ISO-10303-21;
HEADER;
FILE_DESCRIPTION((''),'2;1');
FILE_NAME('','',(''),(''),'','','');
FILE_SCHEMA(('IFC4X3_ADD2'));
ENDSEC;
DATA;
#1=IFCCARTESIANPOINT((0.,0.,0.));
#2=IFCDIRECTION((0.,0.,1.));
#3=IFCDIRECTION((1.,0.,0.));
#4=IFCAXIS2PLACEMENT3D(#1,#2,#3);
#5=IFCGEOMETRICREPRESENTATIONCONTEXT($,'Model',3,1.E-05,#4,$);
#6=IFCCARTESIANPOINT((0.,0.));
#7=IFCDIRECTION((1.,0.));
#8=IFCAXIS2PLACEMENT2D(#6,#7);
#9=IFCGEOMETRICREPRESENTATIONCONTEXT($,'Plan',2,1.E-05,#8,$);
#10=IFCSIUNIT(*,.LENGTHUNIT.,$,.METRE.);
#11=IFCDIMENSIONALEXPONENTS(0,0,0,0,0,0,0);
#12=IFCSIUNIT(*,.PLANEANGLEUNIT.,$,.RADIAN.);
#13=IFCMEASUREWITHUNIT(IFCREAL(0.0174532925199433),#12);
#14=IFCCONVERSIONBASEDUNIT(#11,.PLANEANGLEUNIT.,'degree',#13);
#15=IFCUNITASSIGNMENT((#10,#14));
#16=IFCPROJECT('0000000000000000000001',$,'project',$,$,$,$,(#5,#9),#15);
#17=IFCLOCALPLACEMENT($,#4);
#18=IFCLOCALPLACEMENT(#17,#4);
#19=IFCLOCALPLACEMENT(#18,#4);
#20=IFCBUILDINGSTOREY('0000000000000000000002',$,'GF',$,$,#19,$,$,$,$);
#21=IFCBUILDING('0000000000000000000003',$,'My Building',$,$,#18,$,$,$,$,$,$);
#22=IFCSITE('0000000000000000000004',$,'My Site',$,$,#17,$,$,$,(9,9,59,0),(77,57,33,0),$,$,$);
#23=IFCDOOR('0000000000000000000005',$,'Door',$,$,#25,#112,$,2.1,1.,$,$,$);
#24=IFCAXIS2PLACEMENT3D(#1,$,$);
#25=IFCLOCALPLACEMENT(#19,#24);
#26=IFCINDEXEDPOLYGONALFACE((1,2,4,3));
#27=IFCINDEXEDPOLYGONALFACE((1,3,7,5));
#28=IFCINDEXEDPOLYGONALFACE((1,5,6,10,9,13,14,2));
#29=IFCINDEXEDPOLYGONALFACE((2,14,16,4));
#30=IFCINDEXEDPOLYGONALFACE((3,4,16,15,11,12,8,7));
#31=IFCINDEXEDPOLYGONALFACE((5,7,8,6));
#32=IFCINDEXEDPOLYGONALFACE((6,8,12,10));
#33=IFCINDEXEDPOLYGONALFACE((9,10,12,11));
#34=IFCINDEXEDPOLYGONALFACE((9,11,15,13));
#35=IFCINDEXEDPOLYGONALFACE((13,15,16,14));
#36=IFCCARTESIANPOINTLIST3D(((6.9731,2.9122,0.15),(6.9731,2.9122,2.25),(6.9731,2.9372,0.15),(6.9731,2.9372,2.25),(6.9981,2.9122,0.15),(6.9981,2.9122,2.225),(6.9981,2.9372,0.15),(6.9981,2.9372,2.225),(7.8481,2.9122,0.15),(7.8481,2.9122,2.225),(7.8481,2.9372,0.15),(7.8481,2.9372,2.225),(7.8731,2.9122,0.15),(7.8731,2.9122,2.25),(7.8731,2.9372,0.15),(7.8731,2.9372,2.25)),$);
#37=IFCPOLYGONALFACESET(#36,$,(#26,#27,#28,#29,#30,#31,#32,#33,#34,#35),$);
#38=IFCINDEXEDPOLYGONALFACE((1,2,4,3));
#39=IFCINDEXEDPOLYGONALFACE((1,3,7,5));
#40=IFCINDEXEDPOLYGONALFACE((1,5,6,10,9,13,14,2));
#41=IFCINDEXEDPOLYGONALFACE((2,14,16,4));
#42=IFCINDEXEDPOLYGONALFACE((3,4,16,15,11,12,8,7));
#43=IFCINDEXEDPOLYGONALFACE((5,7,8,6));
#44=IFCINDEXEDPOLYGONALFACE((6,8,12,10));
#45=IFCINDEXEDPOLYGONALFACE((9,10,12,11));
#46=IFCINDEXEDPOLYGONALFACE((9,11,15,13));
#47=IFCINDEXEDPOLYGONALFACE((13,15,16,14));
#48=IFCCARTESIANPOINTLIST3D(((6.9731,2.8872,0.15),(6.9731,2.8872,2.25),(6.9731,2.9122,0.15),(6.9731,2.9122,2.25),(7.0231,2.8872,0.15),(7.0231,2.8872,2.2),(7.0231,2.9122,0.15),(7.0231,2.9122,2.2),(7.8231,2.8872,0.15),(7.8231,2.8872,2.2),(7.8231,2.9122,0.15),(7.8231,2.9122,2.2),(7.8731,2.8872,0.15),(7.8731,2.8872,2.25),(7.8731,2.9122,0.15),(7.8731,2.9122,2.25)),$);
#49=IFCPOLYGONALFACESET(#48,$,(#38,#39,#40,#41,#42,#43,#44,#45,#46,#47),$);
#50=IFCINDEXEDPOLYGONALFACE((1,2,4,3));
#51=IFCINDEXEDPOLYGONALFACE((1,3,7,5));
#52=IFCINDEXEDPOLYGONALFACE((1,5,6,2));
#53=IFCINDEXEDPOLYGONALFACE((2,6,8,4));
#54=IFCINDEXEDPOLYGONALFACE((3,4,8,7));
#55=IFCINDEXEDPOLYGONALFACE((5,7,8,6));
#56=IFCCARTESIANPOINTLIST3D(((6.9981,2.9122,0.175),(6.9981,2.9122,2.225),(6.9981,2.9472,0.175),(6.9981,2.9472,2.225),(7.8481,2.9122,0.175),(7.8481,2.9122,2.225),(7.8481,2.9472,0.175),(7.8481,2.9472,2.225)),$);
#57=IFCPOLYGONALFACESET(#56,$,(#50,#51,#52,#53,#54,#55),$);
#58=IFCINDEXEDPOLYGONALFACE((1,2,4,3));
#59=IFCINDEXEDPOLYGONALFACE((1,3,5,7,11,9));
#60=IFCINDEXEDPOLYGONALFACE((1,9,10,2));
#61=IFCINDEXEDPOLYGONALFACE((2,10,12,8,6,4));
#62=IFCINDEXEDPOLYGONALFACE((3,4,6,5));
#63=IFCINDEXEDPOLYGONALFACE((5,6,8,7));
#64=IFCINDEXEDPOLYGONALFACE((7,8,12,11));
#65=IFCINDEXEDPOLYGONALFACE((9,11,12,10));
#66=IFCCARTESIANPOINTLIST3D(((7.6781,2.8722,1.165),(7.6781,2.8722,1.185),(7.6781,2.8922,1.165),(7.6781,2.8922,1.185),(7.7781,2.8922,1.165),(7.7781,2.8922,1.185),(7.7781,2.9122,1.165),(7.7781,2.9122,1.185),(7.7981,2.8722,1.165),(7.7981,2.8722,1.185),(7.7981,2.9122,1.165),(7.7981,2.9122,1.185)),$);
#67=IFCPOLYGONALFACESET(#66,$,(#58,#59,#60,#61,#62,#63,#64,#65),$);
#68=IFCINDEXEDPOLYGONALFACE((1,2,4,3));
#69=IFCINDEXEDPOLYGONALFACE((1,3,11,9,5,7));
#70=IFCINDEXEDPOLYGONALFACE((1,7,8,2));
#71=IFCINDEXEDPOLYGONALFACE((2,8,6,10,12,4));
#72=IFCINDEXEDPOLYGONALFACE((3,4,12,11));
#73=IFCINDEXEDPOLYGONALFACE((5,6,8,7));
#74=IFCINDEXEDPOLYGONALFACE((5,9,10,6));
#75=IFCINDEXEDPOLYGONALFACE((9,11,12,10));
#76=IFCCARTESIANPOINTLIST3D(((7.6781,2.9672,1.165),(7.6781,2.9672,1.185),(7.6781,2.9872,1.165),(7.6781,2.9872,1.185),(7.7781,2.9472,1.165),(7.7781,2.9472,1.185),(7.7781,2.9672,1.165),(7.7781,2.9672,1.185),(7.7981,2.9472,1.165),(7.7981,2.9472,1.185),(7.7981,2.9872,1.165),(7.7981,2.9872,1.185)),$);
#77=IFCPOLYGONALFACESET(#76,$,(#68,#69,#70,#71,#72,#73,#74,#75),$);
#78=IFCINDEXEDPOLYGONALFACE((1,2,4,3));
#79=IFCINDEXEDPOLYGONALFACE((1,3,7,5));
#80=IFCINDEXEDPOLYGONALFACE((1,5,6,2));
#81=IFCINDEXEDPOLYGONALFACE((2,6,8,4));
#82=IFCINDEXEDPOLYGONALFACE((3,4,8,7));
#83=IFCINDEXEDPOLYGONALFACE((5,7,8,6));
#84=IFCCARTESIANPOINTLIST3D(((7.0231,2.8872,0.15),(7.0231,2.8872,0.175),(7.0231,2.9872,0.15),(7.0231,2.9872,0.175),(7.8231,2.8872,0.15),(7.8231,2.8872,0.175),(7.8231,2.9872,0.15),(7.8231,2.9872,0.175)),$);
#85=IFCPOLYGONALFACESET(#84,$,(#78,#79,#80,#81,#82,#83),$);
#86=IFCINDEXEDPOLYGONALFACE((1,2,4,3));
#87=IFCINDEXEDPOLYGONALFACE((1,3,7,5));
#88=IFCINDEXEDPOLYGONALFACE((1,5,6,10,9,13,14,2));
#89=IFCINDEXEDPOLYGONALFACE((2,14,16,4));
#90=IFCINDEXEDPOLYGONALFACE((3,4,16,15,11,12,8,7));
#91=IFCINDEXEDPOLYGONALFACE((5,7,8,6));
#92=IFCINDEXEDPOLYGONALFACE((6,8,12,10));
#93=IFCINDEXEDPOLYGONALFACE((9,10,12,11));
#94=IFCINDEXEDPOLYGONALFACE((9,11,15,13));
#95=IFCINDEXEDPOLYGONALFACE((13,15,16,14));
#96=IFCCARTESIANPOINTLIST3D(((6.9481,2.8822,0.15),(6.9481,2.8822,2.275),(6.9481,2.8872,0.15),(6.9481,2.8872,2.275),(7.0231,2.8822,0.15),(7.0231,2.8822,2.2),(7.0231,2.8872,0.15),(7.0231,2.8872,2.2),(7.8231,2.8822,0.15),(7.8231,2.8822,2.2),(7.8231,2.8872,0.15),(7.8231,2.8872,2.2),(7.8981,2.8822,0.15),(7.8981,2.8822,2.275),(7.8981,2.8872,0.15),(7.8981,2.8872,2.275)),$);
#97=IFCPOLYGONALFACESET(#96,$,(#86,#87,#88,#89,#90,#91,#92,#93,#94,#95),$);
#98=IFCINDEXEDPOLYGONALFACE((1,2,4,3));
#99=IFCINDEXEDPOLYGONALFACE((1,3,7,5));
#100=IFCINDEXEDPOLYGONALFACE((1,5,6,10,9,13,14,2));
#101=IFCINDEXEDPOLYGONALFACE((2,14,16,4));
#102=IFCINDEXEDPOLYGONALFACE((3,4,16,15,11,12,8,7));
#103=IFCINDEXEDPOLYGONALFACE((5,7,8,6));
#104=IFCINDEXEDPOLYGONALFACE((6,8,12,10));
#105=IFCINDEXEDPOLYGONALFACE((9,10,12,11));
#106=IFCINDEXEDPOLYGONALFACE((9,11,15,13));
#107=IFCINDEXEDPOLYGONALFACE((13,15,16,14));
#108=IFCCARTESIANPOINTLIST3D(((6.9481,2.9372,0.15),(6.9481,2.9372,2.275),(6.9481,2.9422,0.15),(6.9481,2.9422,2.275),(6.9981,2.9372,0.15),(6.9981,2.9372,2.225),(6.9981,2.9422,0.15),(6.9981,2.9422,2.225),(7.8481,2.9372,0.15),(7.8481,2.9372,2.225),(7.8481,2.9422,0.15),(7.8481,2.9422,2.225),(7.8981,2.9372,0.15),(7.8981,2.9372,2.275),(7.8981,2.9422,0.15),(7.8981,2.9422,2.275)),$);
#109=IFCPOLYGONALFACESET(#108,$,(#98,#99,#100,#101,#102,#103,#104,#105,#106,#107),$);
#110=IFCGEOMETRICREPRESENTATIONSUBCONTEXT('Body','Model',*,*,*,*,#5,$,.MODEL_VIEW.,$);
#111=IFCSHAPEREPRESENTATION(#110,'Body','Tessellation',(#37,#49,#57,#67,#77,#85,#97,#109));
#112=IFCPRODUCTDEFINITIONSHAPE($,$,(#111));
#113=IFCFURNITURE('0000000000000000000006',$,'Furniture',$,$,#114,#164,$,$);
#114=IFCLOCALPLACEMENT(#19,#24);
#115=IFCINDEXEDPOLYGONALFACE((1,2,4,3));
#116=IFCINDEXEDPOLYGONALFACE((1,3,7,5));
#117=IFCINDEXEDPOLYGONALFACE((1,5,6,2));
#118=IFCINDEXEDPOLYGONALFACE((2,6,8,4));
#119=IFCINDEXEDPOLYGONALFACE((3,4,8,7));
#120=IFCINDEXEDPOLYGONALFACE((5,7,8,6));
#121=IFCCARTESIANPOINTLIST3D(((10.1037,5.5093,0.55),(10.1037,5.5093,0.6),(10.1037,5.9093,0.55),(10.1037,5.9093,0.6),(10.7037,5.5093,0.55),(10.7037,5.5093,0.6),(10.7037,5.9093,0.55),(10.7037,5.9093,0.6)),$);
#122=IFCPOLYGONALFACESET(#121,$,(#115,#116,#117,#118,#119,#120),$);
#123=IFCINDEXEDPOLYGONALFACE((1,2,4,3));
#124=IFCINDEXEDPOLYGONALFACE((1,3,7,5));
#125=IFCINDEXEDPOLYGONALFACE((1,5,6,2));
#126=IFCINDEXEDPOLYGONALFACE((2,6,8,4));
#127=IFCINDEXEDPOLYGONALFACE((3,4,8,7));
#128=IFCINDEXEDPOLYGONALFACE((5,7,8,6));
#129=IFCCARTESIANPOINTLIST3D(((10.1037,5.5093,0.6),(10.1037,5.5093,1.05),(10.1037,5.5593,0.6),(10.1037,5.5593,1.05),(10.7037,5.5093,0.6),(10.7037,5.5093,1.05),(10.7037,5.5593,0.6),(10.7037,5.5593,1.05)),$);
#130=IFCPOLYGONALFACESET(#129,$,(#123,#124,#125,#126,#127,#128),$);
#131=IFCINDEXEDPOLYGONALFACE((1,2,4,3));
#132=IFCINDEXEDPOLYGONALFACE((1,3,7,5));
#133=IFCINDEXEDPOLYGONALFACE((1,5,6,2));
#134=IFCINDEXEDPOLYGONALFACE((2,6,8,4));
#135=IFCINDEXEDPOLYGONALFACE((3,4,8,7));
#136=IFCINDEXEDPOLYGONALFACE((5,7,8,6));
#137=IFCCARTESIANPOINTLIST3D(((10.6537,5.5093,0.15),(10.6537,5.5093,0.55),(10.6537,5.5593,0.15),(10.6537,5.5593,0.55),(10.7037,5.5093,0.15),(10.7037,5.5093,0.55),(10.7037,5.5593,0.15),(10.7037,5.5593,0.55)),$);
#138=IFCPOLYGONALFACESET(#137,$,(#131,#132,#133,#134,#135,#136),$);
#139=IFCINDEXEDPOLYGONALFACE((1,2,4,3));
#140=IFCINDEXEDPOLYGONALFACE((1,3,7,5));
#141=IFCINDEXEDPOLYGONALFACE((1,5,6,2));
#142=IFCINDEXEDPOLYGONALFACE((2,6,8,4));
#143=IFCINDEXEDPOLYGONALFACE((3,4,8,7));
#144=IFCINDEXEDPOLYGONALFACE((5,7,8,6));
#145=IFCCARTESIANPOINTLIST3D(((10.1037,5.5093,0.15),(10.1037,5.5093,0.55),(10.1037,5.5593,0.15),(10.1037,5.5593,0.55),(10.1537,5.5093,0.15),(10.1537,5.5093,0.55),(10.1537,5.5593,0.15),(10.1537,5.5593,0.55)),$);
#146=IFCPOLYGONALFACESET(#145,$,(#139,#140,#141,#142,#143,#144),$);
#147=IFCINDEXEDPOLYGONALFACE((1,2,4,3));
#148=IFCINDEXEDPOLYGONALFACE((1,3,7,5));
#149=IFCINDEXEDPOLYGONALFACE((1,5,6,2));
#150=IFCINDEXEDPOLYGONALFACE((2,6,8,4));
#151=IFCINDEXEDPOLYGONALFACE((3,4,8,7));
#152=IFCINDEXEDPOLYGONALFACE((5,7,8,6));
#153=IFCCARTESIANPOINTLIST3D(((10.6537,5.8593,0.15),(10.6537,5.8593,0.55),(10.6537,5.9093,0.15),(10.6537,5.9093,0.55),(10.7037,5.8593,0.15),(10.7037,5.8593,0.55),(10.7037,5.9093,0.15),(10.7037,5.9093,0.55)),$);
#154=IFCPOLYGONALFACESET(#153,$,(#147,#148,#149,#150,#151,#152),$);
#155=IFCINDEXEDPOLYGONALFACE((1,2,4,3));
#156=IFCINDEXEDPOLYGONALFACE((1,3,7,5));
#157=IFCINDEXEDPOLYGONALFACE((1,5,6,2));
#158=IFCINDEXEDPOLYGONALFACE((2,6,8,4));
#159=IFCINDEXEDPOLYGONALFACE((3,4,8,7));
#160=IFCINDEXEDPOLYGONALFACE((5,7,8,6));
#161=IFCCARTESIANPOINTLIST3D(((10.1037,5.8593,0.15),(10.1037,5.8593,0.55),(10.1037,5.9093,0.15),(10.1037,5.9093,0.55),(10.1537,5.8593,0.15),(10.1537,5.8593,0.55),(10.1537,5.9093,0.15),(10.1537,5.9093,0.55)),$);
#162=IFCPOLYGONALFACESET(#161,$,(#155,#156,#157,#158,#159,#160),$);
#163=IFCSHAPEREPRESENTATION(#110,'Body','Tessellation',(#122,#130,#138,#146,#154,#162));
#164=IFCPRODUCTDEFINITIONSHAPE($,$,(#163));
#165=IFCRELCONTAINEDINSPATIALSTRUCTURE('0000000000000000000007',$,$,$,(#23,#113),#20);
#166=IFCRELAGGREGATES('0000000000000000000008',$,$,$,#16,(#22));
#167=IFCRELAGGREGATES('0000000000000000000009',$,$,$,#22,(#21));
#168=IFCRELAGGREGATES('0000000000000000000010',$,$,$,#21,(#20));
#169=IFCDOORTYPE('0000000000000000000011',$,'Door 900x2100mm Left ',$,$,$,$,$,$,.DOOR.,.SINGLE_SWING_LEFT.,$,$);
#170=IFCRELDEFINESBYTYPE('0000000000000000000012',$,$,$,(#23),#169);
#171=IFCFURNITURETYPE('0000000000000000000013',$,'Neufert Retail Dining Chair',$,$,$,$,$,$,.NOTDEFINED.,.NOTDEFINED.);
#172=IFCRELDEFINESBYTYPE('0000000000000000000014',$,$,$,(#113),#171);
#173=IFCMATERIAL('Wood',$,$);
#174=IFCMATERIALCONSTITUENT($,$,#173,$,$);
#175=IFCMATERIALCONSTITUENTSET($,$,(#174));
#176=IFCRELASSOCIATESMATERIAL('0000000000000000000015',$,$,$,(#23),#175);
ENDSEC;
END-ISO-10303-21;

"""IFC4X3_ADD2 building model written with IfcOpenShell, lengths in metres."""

from ifc_helpers import new_model, entity, si_unit, converted_unit, frame, origin_with_axes, origin_2d_with_axis, place, context, subcontext, project, spatial, line, indexed_curve, outline, extrude, shape, source, transform, mapped, material, constituent, constituent_set, type_object, type_shapes, element, save


model = new_model("IFC4X3_ADD2")

# Units and contexts
model_context = context("Model", 3, precision=1e-05, world=origin_with_axes())
plan_context = context("Plan", 2, precision=1e-05, world=origin_2d_with_axis())
body_context_1 = subcontext(model_context, "Body", "Model", "MODEL_VIEW")
body_context_2 = subcontext(plan_context, "Body", "Plan", "PLAN_VIEW")
ifc_project = project(units=[si_unit("LENGTHUNIT", "METRE"), converted_unit("PLANEANGLEUNIT", "degree", entity("IfcReal", 0.0174532925199433), si_unit("PLANEANGLEUNIT", "RADIAN"), dimensions=[0, 0, 0, 0, 0, 0, 0])], contexts=[model_context, plan_context])

# Site, building, storey
site_placement = place(None, origin_with_axes())
site = spatial("IfcSite", under=ifc_project, at=site_placement, Name="My Site", RefLatitude=(9, 9, 59, 0), RefLongitude=(77, 57, 33, 0))
building_placement = place(site_placement, origin_with_axes())
building = spatial("IfcBuilding", under=site, at=building_placement, Name="My Building")
storey_placement = place(building_placement, origin_with_axes())
storey = spatial("IfcBuildingStorey", under=building, at=storey_placement, Name="GF")

# Door
ifc_material_1 = material(Name="Wood")
ifc_constituent = constituent(ifc_material_1)
ifc_constituent_set = constituent_set(constituents=[ifc_constituent])
door_type = type_object("IfcDoorType", Name="Door 900x2100mm Left ", OperationType="SINGLE_SWING_LEFT", PredefinedType="DOOR")
shared_shape_1 = source(origin_with_axes(), body_context_1, "Body", "SweptSolid", [
    extrude(outline(indexed_curve([(0.0, 0.0), (0.0, 2.1), (0.9, 2.1), (0.9, 0.0), (0.875, 0.0), (0.875, 2.075), (0.025, 2.075), (0.025, 0.0)], segments=[line(1, 2, 3, 4, 5, 6, 7, 8, 1)])), frame((0.0, 0.025, 0.0), z_axis=(0.0, -1.0, 0.0), x_axis=(1.0, 0.0, 0.0)), (0.0, 0.0, -1.0), 0.025),
    extrude(outline(indexed_curve([(0.0, 0.0), (0.0, 2.1), (0.9, 2.1), (0.9, 0.0), (0.85, 0.0), (0.85, 2.05), (0.05, 2.05), (0.05, 0.0)], segments=[line(1, 2, 3, 4, 5, 6, 7, 8, 1)])), frame((0.0, 0.0, 0.0), z_axis=(0.0, -1.0, 0.0), x_axis=(1.0, 0.0, 0.0)), (0.0, 0.0, -1.0), 0.025),
    extrude(outline(indexed_curve([(0.0, 0.0), (0.85, 0.0), (0.85, 0.035), (0.0, 0.035)], segments=[line(1, 2, 3, 4, 1)])), frame((0.025, 0.025, 0.025), z_axis=(0.0, 0.0, 1.0), x_axis=(1.0, 0.0, 0.0)), (0.0, 0.0, 1.0), 2.05),
    extrude(outline(indexed_curve([(0.0, 0.0), (0.0, -0.04), (-0.12, -0.04), (-0.12, -0.02), (-0.02, -0.02), (-0.02, 0.0)], segments=[line(1, 2, 3, 4, 5, 6, 1)])), frame((0.825, 0.025, 1.015), z_axis=(0.0, 0.0, 1.0), x_axis=(1.0, 0.0, 0.0)), (0.0, 0.0, 1.0), 0.02),
    extrude(outline(indexed_curve([(0.0, 0.0), (0.0, 0.04), (-0.12, 0.04), (-0.12, 0.02), (-0.02, 0.02), (-0.02, 0.0)], segments=[line(1, 2, 3, 4, 5, 6, 1)])), frame((0.825, 0.06, 1.015), z_axis=(0.0, 0.0, 1.0), x_axis=(1.0, 0.0, 0.0)), (0.0, 0.0, 1.0), 0.02),
    extrude(outline(indexed_curve([(0.0, 0.0), (0.8, 0.0), (0.8, 0.1), (0.0, 0.1)], segments=[line(1, 2, 3, 4, 1)])), frame((0.05, 0.0, 0.0), z_axis=(0.0, 0.0, 1.0), x_axis=(1.0, 0.0, 0.0)), (0.0, 0.0, 1.0), 0.025),
    extrude(outline(indexed_curve([(0.0, 0.0), (0.0, 2.125), (0.95, 2.125), (0.95, 0.0), (0.875, 0.0), (0.875, 2.05), (0.075, 2.05), (0.075, 0.0)], segments=[line(1, 2, 3, 4, 5, 6, 7, 8, 1)])), frame((-0.025, -0.005, 0.0), z_axis=(0.0, -1.0, 0.0), x_axis=(1.0, 0.0, 0.0)), (0.0, 0.0, -1.0), 0.005),
    extrude(outline(indexed_curve([(0.0, 0.0), (0.0, 2.125), (0.95, 2.125), (0.95, 0.0), (0.9, 0.0), (0.9, 2.075), (0.05, 2.075), (0.05, 0.0)], segments=[line(1, 2, 3, 4, 5, 6, 7, 8, 1)])), frame((-0.025, 0.05, 0.0), z_axis=(0.0, -1.0, 0.0), x_axis=(1.0, 0.0, 0.0)), (0.0, 0.0, -1.0), 0.005),
])
shared_shape_2 = source(origin_with_axes(), body_context_2, "Body", "Curve2D", [
    entity("IfcIndexedPolyCurve", entity("IfcCartesianPointList2D", [[0.0, 0.0], [0.0, 0.05], [0.025, 0.05], [0.025, 0.025], [0.05, 0.025], [0.05, 0.0]]), [entity("IfcLineIndex", [1, 2, 3, 4, 5, 6, 1])]),
    entity("IfcIndexedPolyCurve", entity("IfcCartesianPointList2D", [[0.9, 0.0], [0.9, 0.05], [0.875, 0.05], [0.875, 0.025], [0.85, 0.025], [0.85, 0.0]]), [entity("IfcLineIndex", [1, 2, 3, 4, 5, 6, 1])]),
    entity("IfcTrimmedCurve", entity("IfcEllipse", entity("IfcAxis2Placement2D", entity("IfcCartesianPoint", [0.06, 0.05]), entity("IfcDirection", [1.0, 0.0])), 0.815, 0.85), [entity("IfcCartesianPoint", [0.875, 0.05])], [entity("IfcCartesianPoint", [0.06, 0.9])], True, "CARTESIAN"),
    entity("IfcIndexedPolyCurve", entity("IfcCartesianPointList2D", [[0.025, 0.05], [0.06, 0.05], [0.06, 0.9], [0.025, 0.9]]), [entity("IfcLineIndex", [1, 2, 3, 4, 1])]),
])
type_shapes(door_type, [shared_shape_1, shared_shape_2])
door_placement = place(storey_placement, frame((6.9731, 2.8872, 0.15), z_axis=(0.0, 0.0, 1.0), x_axis=(1.0, 0.0, 0.0)))
element("IfcDoor", 1, at=door_placement, inside=storey, type_object=door_type, material=ifc_constituent_set, Name="Door", OverallHeight=2.1, OverallWidth=1.0, shapes=[
    shape(body_context_1, "Body", "MappedRepresentation", [mapped(shared_shape_1, transform((0.0, 0.0, 0.0), x_axis=(1.0, 0.0, 0.0), y_axis=(0.0, 1.0, 0.0), z_axis=(0.0, 0.0, 1.0), scale=1.0))]),
    shape(body_context_2, "Body", "MappedRepresentation", [mapped(shared_shape_2, transform((0.0, 0.0, 0.0), x_axis=(1.0, 0.0, 0.0), y_axis=(0.0, 1.0, 0.0), z_axis=(0.0, 0.0, 1.0), scale=1.0))]),
])

# Furniture
furniture_type = type_object("IfcFurnitureType", Name="Neufert Retail Dining Chair", AssemblyPlace="NOTDEFINED", PredefinedType="NOTDEFINED")
shared_shape_3 = source(origin_with_axes(), body_context_1, "Body", "SweptSolid", [
    extrude(outline(indexed_curve([(-0.3, 0.0), (0.3, 0.0), (0.3, -0.4), (-0.3, -0.4)], segments=[line(1, 2, 3, 4, 1)])), frame((0.0, 0.0, 0.45), z_axis=(0.0, 0.0, 1.0), x_axis=(1.0, 0.0, 0.0)), (0.0, 0.0, -1.0), 0.05),
    extrude(outline(indexed_curve([(-0.3, 0.0), (0.3, 0.0), (0.3, -0.05), (-0.3, -0.05)], segments=[line(1, 2, 3, 4, 1)])), frame((0.0, 0.0, 0.9), z_axis=(0.0, 0.0, 1.0), x_axis=(1.0, 0.0, 0.0)), (0.0, 0.0, -1.0), 0.45),
    extrude(outline(indexed_curve([(-0.3, 0.0), (-0.25, 0.0), (-0.25, -0.05), (-0.3, -0.05)], segments=[line(1, 2, 3, 4, 1)])), origin_with_axes(), (0.0, 0.0, 1.0), 0.4),
    extrude(outline(indexed_curve([(0.3, 0.0), (0.25, 0.0), (0.25, -0.05), (0.3, -0.05)], segments=[line(1, 2, 3, 4, 1)])), origin_with_axes(), (0.0, 0.0, 1.0), 0.4),
    extrude(outline(indexed_curve([(-0.3, -0.4), (-0.25, -0.4), (-0.25, -0.35), (-0.3, -0.35)], segments=[line(1, 2, 3, 4, 1)])), origin_with_axes(), (0.0, 0.0, 1.0), 0.4),
    extrude(outline(indexed_curve([(0.3, -0.4), (0.25, -0.4), (0.25, -0.35), (0.3, -0.35)], segments=[line(1, 2, 3, 4, 1)])), origin_with_axes(), (0.0, 0.0, 1.0), 0.4),
])
shared_shape_4 = source(origin_with_axes(), body_context_2, "Body", "Curve2D", [
    entity("IfcIndexedPolyCurve", entity("IfcCartesianPointList2D", [[-0.3, -0.4], [0.3, -0.4]])),
    entity("IfcIndexedPolyCurve", entity("IfcCartesianPointList2D", [[-0.3, -0.4], [-0.3, -0.3], [-0.2121, -0.0879], [0.0, 0.0], [0.2121, -0.0879], [0.3, -0.3], [0.3, -0.4]]), [entity("IfcLineIndex", [1, 2]), entity("IfcArcIndex", [2, 3, 4]), entity("IfcArcIndex", [4, 5, 6]), entity("IfcLineIndex", [6, 7])]),
    entity("IfcIndexedPolyCurve", entity("IfcCartesianPointList2D", [[-0.26, -0.4], [-0.26, -0.3], [-0.1838, -0.1162], [0.0, -0.04], [0.1838, -0.1162], [0.26, -0.3], [0.26, -0.4]]), [entity("IfcLineIndex", [1, 2]), entity("IfcArcIndex", [2, 3, 4]), entity("IfcArcIndex", [4, 5, 6]), entity("IfcLineIndex", [6, 7])]),
])
type_shapes(furniture_type, [shared_shape_3, shared_shape_4])
for number, where, z_axis, x_axis, name in (
    (2, (10.4037, 5.5093, 0.15), (0.0, 0.0, 1.0), (-1.0, 0.000002, 0.0), "Furniture"),
):
    element("IfcFurniture", number, at=place(storey_placement, frame(where, z_axis=z_axis, x_axis=x_axis)), inside=storey, type_object=furniture_type, Name=name, shapes=[
        shape(body_context_1, "Body", "MappedRepresentation", [mapped(shared_shape_3, transform((0.0, 0.0, 0.0), x_axis=(1.0, 0.0, 0.0), y_axis=(0.0, 1.0, 0.0), z_axis=(0.0, 0.0, 1.0), scale=1.0))]),
        shape(body_context_2, "Body", "MappedRepresentation", [mapped(shared_shape_4, transform((0.0, 0.0, 0.0), x_axis=(1.0, 0.0, 0.0), y_axis=(0.0, 1.0, 0.0), z_axis=(0.0, 0.0, 1.0), scale=1.0))]),
    ])

save(model, "model.ifc")
